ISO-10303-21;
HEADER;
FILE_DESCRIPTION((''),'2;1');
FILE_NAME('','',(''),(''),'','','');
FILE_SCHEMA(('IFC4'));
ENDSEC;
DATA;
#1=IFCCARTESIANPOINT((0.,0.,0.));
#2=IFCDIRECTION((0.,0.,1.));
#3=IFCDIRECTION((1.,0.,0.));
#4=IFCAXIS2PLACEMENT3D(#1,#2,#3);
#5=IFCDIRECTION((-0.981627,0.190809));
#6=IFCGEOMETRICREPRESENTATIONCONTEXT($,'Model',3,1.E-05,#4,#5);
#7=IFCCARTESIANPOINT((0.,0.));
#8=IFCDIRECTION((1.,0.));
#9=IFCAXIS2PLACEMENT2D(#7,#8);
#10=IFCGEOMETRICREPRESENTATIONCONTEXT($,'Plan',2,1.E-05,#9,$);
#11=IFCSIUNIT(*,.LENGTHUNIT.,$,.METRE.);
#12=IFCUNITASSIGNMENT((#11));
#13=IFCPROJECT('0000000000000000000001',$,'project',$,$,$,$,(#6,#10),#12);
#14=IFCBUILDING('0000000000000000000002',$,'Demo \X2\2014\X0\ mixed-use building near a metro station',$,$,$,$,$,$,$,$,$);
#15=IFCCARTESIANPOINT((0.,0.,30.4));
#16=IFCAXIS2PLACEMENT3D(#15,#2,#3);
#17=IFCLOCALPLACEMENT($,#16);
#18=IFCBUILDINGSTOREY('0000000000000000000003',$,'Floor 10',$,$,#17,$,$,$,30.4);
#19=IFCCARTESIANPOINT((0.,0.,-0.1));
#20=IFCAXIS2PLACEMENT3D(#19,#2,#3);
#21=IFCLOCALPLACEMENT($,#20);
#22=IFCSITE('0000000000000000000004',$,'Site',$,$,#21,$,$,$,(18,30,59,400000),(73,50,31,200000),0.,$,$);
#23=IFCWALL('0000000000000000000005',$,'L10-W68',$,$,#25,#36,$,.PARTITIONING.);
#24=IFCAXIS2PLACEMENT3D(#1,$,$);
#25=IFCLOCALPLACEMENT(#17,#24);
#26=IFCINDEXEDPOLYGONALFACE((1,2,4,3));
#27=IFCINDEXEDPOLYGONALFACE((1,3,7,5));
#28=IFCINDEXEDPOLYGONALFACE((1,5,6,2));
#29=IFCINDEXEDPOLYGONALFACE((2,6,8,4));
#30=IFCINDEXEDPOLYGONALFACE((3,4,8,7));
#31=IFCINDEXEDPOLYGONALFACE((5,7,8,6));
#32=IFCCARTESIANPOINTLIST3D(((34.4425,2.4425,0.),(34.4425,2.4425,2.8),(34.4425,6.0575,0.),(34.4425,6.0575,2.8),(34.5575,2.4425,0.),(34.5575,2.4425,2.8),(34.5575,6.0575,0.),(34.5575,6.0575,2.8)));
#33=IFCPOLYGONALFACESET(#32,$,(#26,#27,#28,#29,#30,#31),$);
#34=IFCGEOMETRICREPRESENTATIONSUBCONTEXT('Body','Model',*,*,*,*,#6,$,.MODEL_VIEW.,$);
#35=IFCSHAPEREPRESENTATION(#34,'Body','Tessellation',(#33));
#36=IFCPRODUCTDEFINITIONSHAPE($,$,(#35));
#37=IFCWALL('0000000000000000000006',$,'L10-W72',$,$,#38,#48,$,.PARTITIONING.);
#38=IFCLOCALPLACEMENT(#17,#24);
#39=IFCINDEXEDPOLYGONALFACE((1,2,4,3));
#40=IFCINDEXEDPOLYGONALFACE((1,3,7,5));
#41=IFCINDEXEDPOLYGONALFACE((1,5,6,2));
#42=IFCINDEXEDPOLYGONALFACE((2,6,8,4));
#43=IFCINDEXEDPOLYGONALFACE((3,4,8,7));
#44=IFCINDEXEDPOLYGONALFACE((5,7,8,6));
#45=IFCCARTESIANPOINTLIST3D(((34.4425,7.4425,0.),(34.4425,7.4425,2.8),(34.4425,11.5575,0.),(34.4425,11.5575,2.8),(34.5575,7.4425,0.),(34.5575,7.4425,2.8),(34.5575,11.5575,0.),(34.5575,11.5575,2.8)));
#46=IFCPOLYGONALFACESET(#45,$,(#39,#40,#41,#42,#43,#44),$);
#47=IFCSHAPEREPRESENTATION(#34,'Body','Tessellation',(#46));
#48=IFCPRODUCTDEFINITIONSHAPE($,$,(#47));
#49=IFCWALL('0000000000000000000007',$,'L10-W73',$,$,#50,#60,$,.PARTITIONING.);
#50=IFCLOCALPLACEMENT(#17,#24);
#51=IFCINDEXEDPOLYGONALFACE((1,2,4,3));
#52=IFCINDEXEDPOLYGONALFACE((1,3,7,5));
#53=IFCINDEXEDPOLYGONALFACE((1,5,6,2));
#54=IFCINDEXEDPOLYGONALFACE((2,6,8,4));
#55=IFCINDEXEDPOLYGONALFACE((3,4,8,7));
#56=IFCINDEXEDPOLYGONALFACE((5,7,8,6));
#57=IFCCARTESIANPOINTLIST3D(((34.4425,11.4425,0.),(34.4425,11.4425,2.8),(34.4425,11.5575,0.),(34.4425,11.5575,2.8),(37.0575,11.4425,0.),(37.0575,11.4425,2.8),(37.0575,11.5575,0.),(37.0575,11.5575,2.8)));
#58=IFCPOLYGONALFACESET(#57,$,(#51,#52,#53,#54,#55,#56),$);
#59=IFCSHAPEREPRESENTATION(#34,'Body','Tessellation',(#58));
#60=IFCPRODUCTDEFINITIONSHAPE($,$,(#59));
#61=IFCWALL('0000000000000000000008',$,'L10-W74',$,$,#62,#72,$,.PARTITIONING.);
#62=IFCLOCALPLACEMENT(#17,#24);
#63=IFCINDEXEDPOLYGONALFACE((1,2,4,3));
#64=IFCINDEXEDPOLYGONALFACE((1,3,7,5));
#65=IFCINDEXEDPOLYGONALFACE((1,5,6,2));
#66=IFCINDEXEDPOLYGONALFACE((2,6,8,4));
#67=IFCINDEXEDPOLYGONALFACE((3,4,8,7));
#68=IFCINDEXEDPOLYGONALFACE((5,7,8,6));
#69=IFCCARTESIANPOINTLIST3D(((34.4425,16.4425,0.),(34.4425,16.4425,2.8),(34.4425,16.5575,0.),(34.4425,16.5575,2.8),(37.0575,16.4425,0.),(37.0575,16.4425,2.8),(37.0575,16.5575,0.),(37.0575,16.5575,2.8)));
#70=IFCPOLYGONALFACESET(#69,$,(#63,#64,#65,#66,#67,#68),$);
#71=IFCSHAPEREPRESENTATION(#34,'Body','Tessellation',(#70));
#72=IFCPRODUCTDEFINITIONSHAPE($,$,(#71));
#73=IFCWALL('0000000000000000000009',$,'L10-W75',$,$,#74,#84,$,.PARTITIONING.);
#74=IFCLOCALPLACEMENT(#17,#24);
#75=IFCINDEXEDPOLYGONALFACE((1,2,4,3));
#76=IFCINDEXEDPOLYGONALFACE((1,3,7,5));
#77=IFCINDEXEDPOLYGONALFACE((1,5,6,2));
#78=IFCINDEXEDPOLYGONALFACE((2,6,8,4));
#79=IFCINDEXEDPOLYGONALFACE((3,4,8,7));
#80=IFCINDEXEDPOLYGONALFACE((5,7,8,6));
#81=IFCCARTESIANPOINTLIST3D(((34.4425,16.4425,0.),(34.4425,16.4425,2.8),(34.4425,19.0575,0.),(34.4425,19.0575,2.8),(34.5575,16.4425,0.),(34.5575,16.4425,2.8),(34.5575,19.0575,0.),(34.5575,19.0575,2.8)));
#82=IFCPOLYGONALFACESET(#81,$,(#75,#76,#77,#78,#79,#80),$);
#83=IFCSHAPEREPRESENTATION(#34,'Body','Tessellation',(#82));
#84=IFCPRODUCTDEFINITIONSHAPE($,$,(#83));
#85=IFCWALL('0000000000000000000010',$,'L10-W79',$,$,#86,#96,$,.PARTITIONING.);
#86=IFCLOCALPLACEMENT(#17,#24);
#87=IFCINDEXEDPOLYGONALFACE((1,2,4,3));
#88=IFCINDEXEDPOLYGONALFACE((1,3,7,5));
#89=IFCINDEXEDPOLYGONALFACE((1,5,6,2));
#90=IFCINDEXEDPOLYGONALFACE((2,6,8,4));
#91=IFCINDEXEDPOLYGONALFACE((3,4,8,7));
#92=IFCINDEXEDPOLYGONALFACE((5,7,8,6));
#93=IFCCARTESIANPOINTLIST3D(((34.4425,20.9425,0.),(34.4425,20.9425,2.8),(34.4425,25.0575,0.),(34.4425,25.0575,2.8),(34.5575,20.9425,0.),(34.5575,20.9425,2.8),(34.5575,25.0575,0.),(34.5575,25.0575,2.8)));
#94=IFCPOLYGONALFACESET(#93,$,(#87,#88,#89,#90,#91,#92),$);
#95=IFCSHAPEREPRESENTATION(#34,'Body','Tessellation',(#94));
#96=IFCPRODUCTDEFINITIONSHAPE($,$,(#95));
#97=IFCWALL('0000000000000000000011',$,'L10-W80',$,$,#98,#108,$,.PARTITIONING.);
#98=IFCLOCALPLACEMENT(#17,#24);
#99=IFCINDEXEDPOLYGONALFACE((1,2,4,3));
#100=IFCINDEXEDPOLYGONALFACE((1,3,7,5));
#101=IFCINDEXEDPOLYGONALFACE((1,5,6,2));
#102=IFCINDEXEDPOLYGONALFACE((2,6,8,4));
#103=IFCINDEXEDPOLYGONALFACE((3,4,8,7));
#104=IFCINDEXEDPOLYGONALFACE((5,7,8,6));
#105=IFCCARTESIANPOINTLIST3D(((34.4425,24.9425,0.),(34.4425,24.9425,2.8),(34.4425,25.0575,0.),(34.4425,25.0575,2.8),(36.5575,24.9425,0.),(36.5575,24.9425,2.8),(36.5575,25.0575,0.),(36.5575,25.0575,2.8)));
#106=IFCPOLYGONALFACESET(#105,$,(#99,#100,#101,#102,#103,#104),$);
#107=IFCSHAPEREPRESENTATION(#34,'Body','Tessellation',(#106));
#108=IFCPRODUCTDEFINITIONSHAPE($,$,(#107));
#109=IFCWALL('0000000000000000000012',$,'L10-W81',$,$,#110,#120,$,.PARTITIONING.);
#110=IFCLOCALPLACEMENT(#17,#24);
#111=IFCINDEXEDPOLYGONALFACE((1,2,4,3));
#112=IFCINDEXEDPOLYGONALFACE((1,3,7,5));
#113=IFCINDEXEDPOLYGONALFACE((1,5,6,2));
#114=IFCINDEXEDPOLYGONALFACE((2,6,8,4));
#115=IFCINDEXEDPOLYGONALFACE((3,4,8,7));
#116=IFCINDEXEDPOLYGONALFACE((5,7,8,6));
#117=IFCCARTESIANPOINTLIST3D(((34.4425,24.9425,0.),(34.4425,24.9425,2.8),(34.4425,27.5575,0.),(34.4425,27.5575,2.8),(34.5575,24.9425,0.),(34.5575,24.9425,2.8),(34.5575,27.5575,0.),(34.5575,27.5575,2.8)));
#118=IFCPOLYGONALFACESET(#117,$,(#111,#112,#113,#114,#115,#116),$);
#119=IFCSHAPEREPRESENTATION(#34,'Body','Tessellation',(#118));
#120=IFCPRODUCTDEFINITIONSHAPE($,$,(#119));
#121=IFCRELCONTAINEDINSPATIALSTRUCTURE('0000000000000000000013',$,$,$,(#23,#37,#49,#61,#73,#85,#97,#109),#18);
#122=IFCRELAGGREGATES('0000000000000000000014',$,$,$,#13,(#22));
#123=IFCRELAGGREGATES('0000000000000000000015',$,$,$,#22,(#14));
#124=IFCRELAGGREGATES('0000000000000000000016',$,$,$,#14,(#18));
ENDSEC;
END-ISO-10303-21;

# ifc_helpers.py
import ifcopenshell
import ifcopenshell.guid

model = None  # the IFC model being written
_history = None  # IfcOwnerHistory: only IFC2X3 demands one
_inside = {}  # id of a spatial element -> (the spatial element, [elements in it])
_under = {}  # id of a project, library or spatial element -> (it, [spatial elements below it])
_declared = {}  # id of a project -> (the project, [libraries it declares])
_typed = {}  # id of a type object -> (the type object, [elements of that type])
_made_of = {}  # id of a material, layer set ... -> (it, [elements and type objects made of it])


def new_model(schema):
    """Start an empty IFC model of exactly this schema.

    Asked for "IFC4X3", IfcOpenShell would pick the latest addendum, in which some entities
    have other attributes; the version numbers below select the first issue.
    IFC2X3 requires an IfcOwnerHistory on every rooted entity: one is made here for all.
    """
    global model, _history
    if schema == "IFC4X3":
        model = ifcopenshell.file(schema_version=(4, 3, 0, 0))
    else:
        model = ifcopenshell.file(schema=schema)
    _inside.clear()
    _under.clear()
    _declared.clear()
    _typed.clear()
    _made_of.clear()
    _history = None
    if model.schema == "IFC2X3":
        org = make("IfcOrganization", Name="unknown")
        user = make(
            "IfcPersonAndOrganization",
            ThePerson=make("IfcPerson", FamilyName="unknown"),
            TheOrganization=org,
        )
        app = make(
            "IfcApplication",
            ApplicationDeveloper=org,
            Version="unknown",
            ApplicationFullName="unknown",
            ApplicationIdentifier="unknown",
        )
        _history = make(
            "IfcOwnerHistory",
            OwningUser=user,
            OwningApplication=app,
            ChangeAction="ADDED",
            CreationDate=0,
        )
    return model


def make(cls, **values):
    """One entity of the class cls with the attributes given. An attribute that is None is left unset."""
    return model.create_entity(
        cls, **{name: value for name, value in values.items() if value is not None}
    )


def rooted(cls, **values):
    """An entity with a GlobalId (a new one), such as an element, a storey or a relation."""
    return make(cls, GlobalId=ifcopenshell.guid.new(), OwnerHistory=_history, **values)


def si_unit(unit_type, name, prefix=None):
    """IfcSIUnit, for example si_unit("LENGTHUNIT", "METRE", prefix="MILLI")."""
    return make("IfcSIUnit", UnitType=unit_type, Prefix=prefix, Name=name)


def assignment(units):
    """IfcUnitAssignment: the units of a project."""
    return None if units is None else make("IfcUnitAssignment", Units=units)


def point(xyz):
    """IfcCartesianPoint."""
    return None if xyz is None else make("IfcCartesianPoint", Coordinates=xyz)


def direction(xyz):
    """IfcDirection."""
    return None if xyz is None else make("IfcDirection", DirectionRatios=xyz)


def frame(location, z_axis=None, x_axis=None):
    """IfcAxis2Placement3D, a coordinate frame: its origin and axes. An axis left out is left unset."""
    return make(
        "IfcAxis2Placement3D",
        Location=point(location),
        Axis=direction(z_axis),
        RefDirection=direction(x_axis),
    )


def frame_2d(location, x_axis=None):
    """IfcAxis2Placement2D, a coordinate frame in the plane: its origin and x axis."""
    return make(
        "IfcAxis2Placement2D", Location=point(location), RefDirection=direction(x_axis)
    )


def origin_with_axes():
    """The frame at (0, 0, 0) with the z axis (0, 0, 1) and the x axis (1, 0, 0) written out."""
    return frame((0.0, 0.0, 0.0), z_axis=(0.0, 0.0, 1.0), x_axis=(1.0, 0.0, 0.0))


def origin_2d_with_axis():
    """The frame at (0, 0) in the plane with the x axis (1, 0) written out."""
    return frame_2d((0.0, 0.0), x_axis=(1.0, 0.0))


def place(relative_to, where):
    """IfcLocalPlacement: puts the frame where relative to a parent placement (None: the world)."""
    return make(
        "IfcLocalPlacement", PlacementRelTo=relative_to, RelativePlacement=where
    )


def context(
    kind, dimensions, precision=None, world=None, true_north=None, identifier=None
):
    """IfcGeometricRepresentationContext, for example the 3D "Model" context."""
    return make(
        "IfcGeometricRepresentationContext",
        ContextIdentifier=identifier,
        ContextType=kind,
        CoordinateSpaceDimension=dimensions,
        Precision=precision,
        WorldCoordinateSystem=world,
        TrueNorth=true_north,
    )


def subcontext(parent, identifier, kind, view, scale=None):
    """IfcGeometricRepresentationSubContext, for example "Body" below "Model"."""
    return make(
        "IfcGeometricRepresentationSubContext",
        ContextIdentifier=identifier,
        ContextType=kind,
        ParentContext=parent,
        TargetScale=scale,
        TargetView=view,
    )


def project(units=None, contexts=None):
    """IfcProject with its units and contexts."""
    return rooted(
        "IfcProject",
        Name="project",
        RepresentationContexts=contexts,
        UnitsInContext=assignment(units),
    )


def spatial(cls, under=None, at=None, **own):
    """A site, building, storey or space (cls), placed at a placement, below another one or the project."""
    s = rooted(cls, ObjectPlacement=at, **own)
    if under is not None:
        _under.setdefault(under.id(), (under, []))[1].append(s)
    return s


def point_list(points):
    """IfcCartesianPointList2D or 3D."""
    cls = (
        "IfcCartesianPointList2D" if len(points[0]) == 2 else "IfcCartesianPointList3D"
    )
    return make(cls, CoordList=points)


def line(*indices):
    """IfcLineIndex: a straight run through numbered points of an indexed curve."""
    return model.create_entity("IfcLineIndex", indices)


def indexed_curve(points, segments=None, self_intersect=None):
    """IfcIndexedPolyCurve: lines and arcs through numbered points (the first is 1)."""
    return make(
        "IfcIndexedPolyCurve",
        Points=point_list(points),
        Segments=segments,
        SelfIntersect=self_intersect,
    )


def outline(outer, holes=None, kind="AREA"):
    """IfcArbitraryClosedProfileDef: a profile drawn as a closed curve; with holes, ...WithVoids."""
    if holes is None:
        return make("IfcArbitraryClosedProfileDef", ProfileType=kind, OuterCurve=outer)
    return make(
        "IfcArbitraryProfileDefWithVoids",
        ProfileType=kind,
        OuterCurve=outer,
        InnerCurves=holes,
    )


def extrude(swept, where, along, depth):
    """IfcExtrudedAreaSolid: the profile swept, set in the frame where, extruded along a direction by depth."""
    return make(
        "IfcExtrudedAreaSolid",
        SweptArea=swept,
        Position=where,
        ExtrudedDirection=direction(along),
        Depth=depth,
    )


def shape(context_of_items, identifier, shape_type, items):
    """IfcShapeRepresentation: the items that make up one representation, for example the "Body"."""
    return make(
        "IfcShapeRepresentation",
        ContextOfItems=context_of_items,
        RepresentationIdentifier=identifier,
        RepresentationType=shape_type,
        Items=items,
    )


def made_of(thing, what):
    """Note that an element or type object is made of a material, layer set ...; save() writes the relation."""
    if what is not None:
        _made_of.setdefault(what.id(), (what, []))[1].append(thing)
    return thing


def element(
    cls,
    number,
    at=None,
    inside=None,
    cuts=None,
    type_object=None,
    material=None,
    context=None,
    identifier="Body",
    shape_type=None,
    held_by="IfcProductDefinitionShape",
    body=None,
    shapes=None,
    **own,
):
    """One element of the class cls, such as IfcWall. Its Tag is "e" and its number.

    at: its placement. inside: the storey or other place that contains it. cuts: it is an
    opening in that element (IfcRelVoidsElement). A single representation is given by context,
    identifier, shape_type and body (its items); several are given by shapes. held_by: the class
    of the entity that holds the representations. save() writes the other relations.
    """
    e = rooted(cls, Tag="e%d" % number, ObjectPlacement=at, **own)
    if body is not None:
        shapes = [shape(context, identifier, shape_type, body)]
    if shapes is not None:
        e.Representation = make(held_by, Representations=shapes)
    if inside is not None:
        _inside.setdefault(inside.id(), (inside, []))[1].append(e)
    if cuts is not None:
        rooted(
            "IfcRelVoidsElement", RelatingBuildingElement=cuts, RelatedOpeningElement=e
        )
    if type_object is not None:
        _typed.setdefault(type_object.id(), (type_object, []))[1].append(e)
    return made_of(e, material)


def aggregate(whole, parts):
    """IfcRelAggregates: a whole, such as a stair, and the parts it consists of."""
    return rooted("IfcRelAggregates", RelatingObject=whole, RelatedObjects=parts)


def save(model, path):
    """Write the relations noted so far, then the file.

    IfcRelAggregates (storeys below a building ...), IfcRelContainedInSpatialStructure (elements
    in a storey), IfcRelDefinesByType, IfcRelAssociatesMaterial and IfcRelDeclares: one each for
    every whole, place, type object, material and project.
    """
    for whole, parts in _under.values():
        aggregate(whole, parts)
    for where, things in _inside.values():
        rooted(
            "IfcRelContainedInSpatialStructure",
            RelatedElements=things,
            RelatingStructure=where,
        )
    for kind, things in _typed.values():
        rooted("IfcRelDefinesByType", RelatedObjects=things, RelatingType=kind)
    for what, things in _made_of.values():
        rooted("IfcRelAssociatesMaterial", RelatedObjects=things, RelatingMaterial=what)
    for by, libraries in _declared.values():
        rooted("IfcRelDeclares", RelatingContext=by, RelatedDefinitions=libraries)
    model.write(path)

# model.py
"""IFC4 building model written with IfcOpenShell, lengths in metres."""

from ifc_helpers import new_model, si_unit, direction, frame, origin_with_axes, origin_2d_with_axis, place, context, subcontext, project, spatial, line, indexed_curve, outline, extrude, element, save


model = new_model("IFC4")

# Units and contexts
model_context = context("Model", 3, precision=1e-05, world=origin_with_axes(), true_north=direction((-0.981627, 0.190809)))
plan_context = context("Plan", 2, precision=1e-05, world=origin_2d_with_axis())
body_context = subcontext(model_context, "Body", "Model", "MODEL_VIEW")
ifc_project = project(units=[si_unit("LENGTHUNIT", "METRE")], contexts=[model_context, plan_context])

# Site, building, storey
site_placement = place(None, frame((0.0, 0.0, -0.1), z_axis=(0.0, 0.0, 1.0), x_axis=(1.0, 0.0, 0.0)))
site = spatial("IfcSite", under=ifc_project, at=site_placement, Name="Site", RefLatitude=(18, 30, 59, 400000), RefLongitude=(73, 50, 31, 200000), RefElevation=0.0)
building = spatial("IfcBuilding", under=site, Name="Demo — mixed-use building near a metro station")
storey_placement = place(None, frame((0.0, 0.0, 30.4), z_axis=(0.0, 0.0, 1.0), x_axis=(1.0, 0.0, 0.0)))
storey = spatial("IfcBuildingStorey", under=building, at=storey_placement, Name="Floor 10", Elevation=30.4)

# Wall
wall_1_placement = place(storey_placement, frame((0.0, 0.0, -30.4), z_axis=(0.0, 0.0, 1.0), x_axis=(1.0, 0.0, 0.0)))
element("IfcWall", 1, at=wall_1_placement, inside=storey, Name="L10-W68", PredefinedType="PARTITIONING", context=body_context, shape_type="SweptSolid", body=[
    extrude(outline(indexed_curve([(34.4425, 2.4425), (34.4425, 6.0575), (34.5575, 6.0575), (34.5575, 2.4425)], segments=[line(1, 2, 3, 4, 1)])), frame((0.0, 0.0, 30.4), z_axis=(0.0, 0.0, 1.0), x_axis=(1.0, 0.0, 0.0)), (0.0, 0.0, 1.0), 2.8),
])

# Walls
wall_2_placement = place(storey_placement, frame((0.0, 0.0, -30.4), z_axis=(0.0, 0.0, 1.0), x_axis=(1.0, 0.0, 0.0)))
element("IfcWall", 2, at=wall_2_placement, inside=storey, Name="L10-W72", PredefinedType="PARTITIONING", context=body_context, shape_type="SweptSolid", body=[
    extrude(outline(indexed_curve([(34.4425, 7.4425), (34.4425, 11.5575), (34.5575, 11.5575), (34.5575, 7.4425)], segments=[line(1, 2, 3, 4, 1)])), frame((0.0, 0.0, 30.4), z_axis=(0.0, 0.0, 1.0), x_axis=(1.0, 0.0, 0.0)), (0.0, 0.0, 1.0), 2.8),
])
wall_3_placement = place(storey_placement, frame((0.0, 0.0, -30.4), z_axis=(0.0, 0.0, 1.0), x_axis=(1.0, 0.0, 0.0)))
element("IfcWall", 3, at=wall_3_placement, inside=storey, Name="L10-W73", PredefinedType="PARTITIONING", context=body_context, shape_type="SweptSolid", body=[
    extrude(outline(indexed_curve([(34.4425, 11.5575), (37.0575, 11.5575), (37.0575, 11.4425), (34.4425, 11.4425)], segments=[line(1, 2, 3, 4, 1)])), frame((0.0, 0.0, 30.4), z_axis=(0.0, 0.0, 1.0), x_axis=(1.0, 0.0, 0.0)), (0.0, 0.0, 1.0), 2.8),
])
wall_4_placement = place(storey_placement, frame((0.0, 0.0, -30.4), z_axis=(0.0, 0.0, 1.0), x_axis=(1.0, 0.0, 0.0)))
element("IfcWall", 4, at=wall_4_placement, inside=storey, Name="L10-W74", PredefinedType="PARTITIONING", context=body_context, shape_type="SweptSolid", body=[
    extrude(outline(indexed_curve([(37.0575, 16.4425), (34.4425, 16.4425), (34.4425, 16.5575), (37.0575, 16.5575)], segments=[line(1, 2, 3, 4, 1)])), frame((0.0, 0.0, 30.4), z_axis=(0.0, 0.0, 1.0), x_axis=(1.0, 0.0, 0.0)), (0.0, 0.0, 1.0), 2.8),
])
wall_5_placement = place(storey_placement, frame((0.0, 0.0, -30.4), z_axis=(0.0, 0.0, 1.0), x_axis=(1.0, 0.0, 0.0)))
element("IfcWall", 5, at=wall_5_placement, inside=storey, Name="L10-W75", PredefinedType="PARTITIONING", context=body_context, shape_type="SweptSolid", body=[
    extrude(outline(indexed_curve([(34.4425, 16.4425), (34.4425, 19.0575), (34.5575, 19.0575), (34.5575, 16.4425)], segments=[line(1, 2, 3, 4, 1)])), frame((0.0, 0.0, 30.4), z_axis=(0.0, 0.0, 1.0), x_axis=(1.0, 0.0, 0.0)), (0.0, 0.0, 1.0), 2.8),
])

# Walls
wall_6_placement = place(storey_placement, frame((0.0, 0.0, -30.4), z_axis=(0.0, 0.0, 1.0), x_axis=(1.0, 0.0, 0.0)))
element("IfcWall", 6, at=wall_6_placement, inside=storey, Name="L10-W79", PredefinedType="PARTITIONING", context=body_context, shape_type="SweptSolid", body=[
    extrude(outline(indexed_curve([(34.4425, 20.9425), (34.4425, 25.0575), (34.5575, 25.0575), (34.5575, 20.9425)], segments=[line(1, 2, 3, 4, 1)])), frame((0.0, 0.0, 30.4), z_axis=(0.0, 0.0, 1.0), x_axis=(1.0, 0.0, 0.0)), (0.0, 0.0, 1.0), 2.8),
])
wall_7_placement = place(storey_placement, frame((0.0, 0.0, -30.4), z_axis=(0.0, 0.0, 1.0), x_axis=(1.0, 0.0, 0.0)))
element("IfcWall", 7, at=wall_7_placement, inside=storey, Name="L10-W80", PredefinedType="PARTITIONING", context=body_context, shape_type="SweptSolid", body=[
    extrude(outline(indexed_curve([(36.5575, 24.9425), (34.4425, 24.9425), (34.4425, 25.0575), (36.5575, 25.0575)], segments=[line(1, 2, 3, 4, 1)])), frame((0.0, 0.0, 30.4), z_axis=(0.0, 0.0, 1.0), x_axis=(1.0, 0.0, 0.0)), (0.0, 0.0, 1.0), 2.8),
])
wall_8_placement = place(storey_placement, frame((0.0, 0.0, -30.4), z_axis=(0.0, 0.0, 1.0), x_axis=(1.0, 0.0, 0.0)))
element("IfcWall", 8, at=wall_8_placement, inside=storey, Name="L10-W81", PredefinedType="PARTITIONING", context=body_context, shape_type="SweptSolid", body=[
    extrude(outline(indexed_curve([(34.4425, 24.9425), (34.4425, 27.5575), (34.5575, 27.5575), (34.5575, 24.9425)], segments=[line(1, 2, 3, 4, 1)])), frame((0.0, 0.0, 30.4), z_axis=(0.0, 0.0, 1.0), x_axis=(1.0, 0.0, 0.0)), (0.0, 0.0, 1.0), 2.8),
])

save(model, "model.ifc")
